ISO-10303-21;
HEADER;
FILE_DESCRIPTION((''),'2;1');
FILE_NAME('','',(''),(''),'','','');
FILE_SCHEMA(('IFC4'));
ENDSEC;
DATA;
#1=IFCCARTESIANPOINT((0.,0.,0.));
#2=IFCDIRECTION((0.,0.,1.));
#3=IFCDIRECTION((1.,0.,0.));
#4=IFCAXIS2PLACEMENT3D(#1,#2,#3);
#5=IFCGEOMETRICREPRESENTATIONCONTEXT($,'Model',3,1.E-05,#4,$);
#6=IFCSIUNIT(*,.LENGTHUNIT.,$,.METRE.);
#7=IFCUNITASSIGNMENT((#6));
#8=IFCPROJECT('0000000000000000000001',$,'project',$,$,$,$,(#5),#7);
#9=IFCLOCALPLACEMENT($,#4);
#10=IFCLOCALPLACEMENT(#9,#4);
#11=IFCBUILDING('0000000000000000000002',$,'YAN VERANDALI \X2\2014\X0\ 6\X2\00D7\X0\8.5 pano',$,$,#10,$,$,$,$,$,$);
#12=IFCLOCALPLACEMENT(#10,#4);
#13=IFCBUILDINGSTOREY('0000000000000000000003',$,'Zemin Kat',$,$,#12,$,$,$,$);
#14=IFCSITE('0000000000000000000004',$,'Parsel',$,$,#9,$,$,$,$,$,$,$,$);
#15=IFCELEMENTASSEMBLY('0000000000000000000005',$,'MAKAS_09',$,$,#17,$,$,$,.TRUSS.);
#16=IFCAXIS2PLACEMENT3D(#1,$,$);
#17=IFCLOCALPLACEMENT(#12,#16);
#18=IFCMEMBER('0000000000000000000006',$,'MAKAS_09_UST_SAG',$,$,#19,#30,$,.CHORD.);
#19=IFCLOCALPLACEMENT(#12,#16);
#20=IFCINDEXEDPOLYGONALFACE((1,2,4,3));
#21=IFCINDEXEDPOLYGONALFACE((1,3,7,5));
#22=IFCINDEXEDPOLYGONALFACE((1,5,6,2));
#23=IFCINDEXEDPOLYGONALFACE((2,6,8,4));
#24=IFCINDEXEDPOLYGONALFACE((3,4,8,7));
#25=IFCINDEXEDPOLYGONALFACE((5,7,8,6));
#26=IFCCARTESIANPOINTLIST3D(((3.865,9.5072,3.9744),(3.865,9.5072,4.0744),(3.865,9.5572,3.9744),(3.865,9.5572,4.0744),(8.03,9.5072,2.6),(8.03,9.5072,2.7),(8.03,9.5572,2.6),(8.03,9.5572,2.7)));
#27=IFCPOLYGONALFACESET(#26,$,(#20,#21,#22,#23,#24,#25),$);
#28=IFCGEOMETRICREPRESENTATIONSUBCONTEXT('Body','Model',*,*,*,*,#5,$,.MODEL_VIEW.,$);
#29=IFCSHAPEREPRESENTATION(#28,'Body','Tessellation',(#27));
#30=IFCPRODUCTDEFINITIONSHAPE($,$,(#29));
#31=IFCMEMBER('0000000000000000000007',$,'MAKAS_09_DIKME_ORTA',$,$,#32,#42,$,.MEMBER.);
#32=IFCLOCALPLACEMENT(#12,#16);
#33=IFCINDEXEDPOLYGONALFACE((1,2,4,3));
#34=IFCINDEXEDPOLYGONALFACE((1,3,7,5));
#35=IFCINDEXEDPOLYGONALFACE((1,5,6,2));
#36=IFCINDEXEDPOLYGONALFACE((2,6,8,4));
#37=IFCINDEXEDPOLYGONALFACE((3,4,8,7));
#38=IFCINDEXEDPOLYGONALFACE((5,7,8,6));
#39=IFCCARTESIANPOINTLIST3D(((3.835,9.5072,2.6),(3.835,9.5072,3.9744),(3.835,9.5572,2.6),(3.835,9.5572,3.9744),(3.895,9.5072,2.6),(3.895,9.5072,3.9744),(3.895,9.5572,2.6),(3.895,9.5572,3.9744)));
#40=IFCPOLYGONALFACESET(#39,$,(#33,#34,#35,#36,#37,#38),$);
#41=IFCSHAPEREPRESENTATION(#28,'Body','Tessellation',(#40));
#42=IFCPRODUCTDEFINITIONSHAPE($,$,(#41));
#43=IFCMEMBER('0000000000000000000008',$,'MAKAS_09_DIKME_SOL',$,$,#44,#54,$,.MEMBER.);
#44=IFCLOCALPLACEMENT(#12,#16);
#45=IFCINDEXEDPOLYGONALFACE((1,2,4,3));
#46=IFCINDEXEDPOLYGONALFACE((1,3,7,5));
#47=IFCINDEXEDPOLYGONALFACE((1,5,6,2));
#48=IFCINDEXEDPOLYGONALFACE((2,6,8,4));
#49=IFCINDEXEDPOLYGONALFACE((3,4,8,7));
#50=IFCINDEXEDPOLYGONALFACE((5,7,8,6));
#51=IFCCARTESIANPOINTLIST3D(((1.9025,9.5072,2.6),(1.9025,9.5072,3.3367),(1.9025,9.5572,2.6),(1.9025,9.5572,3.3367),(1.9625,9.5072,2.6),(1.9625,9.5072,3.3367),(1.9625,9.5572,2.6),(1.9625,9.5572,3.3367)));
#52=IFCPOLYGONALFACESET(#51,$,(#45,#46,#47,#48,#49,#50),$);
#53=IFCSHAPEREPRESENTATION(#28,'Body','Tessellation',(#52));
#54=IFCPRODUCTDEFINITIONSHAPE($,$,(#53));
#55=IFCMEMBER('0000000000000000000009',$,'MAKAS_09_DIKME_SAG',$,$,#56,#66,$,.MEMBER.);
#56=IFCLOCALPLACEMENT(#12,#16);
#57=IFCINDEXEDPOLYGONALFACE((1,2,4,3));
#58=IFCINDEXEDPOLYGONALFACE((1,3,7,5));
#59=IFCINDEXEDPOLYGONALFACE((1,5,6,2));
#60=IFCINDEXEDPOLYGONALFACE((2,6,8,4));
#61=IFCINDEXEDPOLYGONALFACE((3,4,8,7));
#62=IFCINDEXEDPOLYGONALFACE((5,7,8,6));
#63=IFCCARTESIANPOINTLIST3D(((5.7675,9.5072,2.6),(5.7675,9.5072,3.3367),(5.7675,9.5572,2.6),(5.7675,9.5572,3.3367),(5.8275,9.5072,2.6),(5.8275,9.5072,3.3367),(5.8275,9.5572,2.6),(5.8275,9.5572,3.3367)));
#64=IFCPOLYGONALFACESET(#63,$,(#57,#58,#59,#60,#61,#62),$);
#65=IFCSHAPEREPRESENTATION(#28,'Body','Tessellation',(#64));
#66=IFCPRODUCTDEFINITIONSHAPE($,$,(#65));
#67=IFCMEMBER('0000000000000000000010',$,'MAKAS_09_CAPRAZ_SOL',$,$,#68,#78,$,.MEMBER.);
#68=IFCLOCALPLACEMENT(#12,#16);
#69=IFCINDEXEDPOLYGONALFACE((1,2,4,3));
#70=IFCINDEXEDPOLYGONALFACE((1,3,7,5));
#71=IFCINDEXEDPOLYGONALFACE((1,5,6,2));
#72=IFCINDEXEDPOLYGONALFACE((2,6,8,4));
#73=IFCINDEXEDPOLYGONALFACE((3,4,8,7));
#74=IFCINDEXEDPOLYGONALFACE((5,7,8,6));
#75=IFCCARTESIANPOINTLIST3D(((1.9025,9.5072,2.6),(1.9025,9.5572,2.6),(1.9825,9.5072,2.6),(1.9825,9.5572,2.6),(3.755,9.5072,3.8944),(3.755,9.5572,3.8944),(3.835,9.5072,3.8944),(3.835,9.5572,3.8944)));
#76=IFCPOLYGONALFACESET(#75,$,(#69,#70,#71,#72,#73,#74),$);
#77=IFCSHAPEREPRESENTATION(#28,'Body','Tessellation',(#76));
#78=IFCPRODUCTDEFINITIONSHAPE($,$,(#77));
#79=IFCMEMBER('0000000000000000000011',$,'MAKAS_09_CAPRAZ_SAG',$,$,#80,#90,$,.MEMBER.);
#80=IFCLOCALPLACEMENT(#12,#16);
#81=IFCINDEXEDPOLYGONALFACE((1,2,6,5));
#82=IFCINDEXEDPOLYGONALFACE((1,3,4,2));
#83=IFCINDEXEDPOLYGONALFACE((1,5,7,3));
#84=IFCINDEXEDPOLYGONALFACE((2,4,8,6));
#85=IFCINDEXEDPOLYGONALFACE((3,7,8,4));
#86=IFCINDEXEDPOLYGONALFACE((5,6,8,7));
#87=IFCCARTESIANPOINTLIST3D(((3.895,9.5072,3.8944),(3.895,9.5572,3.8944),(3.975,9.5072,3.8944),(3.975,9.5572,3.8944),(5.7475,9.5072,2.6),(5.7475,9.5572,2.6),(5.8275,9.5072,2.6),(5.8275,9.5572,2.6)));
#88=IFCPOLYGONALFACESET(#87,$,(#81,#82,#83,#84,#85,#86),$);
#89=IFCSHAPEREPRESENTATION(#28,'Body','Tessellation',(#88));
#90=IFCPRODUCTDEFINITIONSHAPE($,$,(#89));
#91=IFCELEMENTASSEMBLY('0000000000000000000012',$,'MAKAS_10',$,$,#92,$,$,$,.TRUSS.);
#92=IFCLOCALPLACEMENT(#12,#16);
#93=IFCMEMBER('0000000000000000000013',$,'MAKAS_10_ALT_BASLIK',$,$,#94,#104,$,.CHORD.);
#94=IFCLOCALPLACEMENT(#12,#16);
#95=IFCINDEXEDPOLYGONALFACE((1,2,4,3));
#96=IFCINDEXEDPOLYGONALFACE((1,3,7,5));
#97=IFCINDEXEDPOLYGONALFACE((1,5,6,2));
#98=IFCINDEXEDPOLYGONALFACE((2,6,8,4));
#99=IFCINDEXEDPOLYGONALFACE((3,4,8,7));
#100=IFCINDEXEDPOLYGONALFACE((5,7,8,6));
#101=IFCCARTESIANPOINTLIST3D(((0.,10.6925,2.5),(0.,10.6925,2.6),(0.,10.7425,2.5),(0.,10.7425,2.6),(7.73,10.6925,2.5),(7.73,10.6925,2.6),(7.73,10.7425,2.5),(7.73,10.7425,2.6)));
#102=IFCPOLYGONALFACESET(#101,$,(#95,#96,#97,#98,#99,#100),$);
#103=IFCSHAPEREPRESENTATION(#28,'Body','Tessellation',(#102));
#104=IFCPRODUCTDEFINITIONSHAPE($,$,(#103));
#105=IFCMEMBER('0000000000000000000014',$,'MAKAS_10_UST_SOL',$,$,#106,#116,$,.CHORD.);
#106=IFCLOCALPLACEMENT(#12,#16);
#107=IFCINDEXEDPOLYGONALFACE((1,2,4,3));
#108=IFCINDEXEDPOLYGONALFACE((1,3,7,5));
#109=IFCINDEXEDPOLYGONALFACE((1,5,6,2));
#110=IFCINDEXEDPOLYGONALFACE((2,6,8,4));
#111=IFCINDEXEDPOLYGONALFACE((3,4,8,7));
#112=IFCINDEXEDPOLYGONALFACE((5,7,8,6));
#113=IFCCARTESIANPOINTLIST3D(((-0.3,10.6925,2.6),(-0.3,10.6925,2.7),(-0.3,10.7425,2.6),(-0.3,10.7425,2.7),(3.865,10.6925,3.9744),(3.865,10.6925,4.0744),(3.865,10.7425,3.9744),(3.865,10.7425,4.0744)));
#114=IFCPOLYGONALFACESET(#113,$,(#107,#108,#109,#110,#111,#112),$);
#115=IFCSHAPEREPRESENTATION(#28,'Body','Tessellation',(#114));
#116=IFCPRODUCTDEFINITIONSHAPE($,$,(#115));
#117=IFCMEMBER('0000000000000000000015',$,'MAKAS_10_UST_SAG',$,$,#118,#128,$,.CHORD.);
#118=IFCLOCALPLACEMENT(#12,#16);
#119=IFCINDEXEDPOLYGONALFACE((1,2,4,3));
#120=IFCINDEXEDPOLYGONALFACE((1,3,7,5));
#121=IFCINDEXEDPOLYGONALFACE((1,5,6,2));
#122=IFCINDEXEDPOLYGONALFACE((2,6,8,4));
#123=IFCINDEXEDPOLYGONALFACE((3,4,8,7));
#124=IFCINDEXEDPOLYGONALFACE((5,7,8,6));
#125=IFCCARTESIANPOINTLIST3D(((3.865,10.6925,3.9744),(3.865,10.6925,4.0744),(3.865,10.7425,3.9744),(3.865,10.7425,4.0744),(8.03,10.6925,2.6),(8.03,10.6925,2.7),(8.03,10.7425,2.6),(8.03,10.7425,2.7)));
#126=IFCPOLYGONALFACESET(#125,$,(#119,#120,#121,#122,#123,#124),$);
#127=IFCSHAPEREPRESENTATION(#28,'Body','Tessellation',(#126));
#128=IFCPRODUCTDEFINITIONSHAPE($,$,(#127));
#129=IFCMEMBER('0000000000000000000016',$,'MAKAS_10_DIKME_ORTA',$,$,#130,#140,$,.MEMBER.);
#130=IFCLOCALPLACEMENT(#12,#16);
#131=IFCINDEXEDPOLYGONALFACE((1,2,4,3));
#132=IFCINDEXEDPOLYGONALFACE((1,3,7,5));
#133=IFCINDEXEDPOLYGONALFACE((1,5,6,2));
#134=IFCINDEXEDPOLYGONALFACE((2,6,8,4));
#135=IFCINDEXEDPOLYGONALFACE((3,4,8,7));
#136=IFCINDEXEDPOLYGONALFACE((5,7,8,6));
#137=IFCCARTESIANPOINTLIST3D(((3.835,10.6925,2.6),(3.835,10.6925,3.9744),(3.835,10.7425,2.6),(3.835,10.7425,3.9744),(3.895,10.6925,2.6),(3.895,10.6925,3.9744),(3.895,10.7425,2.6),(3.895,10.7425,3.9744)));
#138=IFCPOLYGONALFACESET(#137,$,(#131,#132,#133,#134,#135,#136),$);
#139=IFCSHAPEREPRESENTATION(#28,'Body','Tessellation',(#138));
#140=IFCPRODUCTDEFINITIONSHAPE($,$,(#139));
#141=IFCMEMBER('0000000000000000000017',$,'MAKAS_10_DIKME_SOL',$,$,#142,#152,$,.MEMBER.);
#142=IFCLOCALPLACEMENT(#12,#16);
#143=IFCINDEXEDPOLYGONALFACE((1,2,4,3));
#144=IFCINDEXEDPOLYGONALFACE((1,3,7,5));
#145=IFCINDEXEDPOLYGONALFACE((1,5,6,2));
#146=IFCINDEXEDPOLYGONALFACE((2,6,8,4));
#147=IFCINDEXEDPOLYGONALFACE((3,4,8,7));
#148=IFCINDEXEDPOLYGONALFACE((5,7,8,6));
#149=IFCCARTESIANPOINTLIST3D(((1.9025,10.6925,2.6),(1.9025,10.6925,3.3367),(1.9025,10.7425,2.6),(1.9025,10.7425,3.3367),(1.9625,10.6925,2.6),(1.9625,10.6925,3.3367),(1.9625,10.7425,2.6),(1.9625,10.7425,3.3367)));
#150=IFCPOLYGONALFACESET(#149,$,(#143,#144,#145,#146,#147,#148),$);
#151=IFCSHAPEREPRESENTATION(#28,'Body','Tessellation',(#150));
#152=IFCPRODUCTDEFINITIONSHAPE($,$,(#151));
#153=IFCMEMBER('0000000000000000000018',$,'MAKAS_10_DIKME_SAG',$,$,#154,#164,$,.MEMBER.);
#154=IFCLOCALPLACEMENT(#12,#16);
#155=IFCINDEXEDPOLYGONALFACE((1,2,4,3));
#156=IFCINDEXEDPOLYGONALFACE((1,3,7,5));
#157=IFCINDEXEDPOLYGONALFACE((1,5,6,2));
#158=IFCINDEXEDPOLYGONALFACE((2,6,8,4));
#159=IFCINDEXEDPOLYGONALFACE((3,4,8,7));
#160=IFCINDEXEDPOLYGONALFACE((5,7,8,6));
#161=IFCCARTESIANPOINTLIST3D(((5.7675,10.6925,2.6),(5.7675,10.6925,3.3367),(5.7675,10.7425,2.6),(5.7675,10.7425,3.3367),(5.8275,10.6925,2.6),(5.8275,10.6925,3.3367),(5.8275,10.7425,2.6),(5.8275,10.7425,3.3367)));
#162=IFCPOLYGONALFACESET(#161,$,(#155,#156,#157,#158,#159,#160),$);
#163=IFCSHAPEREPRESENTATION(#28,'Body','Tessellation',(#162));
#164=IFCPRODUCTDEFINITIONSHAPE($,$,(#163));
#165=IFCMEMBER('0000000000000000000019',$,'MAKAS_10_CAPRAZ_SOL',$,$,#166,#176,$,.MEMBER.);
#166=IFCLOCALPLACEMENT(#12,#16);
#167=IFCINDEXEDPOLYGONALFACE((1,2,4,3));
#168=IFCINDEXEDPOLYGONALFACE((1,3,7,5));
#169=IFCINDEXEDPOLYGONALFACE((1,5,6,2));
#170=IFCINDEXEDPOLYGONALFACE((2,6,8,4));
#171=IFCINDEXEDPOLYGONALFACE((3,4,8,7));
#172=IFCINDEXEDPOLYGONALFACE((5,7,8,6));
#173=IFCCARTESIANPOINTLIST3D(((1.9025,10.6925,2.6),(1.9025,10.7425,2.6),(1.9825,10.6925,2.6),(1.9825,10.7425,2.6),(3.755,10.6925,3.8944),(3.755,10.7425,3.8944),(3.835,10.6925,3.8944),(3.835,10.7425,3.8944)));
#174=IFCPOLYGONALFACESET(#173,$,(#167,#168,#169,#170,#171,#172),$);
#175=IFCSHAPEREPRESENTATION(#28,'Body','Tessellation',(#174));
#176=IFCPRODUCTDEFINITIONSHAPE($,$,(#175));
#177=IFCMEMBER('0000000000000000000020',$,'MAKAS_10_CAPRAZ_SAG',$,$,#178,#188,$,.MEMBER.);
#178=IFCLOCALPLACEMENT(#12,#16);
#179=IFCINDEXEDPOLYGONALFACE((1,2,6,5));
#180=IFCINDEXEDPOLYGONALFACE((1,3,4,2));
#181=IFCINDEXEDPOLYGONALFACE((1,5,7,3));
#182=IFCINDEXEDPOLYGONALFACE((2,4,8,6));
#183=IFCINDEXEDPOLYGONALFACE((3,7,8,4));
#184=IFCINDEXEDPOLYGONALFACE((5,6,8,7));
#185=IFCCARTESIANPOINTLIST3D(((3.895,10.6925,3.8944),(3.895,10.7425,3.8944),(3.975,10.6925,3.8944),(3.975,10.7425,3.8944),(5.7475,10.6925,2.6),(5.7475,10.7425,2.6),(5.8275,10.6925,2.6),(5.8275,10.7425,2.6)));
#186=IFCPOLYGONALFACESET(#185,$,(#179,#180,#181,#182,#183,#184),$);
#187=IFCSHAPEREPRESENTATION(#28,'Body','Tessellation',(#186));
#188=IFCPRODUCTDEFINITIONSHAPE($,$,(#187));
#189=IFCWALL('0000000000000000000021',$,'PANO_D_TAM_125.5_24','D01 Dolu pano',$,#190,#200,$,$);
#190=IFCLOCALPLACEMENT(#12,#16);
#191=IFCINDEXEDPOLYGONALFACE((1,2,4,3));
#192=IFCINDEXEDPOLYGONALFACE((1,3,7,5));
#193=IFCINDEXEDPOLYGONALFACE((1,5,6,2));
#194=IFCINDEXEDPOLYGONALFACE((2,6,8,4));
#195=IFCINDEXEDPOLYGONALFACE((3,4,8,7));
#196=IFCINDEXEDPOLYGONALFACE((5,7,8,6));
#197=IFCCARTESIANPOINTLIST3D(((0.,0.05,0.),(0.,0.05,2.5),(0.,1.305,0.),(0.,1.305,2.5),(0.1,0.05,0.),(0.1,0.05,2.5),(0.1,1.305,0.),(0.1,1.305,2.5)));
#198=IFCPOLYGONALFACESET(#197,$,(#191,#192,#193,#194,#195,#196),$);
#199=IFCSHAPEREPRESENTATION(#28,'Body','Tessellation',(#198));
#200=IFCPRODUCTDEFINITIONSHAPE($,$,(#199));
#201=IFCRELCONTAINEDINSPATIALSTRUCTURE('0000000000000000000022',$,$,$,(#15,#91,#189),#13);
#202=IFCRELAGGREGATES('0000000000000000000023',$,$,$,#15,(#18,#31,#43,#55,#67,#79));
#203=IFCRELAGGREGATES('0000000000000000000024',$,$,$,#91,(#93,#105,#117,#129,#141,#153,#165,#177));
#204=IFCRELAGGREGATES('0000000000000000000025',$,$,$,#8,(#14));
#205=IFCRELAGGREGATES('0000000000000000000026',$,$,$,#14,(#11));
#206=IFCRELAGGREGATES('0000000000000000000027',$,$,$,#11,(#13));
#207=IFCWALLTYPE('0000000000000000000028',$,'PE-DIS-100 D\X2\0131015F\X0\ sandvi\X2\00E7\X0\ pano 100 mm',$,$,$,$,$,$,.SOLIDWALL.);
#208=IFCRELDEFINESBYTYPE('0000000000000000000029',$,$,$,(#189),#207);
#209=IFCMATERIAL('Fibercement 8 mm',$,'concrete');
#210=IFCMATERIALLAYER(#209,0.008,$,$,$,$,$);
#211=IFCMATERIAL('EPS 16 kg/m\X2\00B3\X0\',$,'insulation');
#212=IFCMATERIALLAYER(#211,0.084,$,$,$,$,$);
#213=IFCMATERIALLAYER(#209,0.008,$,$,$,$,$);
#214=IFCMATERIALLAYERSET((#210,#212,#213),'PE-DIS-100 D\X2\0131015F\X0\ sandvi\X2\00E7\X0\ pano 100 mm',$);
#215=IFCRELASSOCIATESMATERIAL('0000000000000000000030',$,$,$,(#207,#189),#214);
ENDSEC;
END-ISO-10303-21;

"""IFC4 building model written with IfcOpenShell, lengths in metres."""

from ifc_helpers import new_model, si_unit, frame, origin_with_axes, place, context, subcontext, project, spatial, line, indexed_curve, outline, extrude, material, layer, layer_set, layer_usage, type_object, element, aggregate, save


model = new_model("IFC4")

# Units and contexts
model_context = context("Model", 3, precision=1e-05, world=origin_with_axes())
body_context = subcontext(model_context, "Body", "Model", "MODEL_VIEW")
ifc_project = project(units=[si_unit("LENGTHUNIT", "METRE")], contexts=[model_context])

# Site, building, storey
site_placement = place(None, origin_with_axes())
site = spatial("IfcSite", under=ifc_project, at=site_placement, Name="Parsel")
building_placement = place(site_placement, origin_with_axes())
building = spatial("IfcBuilding", under=site, at=building_placement, Name="YAN VERANDALI — 6×8.5 pano")
storey_placement = place(building_placement, origin_with_axes())
storey = spatial("IfcBuildingStorey", under=building, at=storey_placement, Name="Zemin Kat")

# Element assemblies, members
assembly_1_placement = place(storey_placement, origin_with_axes())
assembly_1 = element("IfcElementAssembly", 1, at=assembly_1_placement, inside=storey, Name="MAKAS_09", PredefinedType="TRUSS")
member_1_placement = place(assembly_1_placement, origin_with_axes())
member_1 = element("IfcMember", 2, at=member_1_placement, Name="MAKAS_09_UST_SAG", PredefinedType="CHORD", context=body_context, shape_type="SweptSolid", body=[
    extrude(outline(indexed_curve([(3.865, 3.9745), (8.03, 2.6), (8.03, 2.7), (3.865, 4.0744)], segments=[line(1, 2, 3, 4, 1)])), frame((0.0, 9.5572, 0.0), z_axis=(0.0, -1.0, 0.0), x_axis=(1.0, 0.0, 0.0)), (0.0, 0.0, 1.0), 0.05),
])
member_2_placement = place(assembly_1_placement, origin_with_axes())
member_2 = element("IfcMember", 3, at=member_2_placement, Name="MAKAS_09_DIKME_ORTA", PredefinedType="MEMBER", context=body_context, shape_type="SweptSolid", body=[
    extrude(outline(indexed_curve([(3.835, 2.6), (3.895, 2.6), (3.895, 3.9745), (3.835, 3.9745)], segments=[line(1, 2, 3, 4, 1)])), frame((0.0, 9.5572, 0.0), z_axis=(0.0, -1.0, 0.0), x_axis=(1.0, 0.0, 0.0)), (0.0, 0.0, 1.0), 0.05),
])
member_3_placement = place(assembly_1_placement, origin_with_axes())
member_3 = element("IfcMember", 4, at=member_3_placement, Name="MAKAS_09_DIKME_SOL", PredefinedType="MEMBER", context=body_context, shape_type="SweptSolid", body=[
    extrude(outline(indexed_curve([(1.9025, 2.6), (1.9625, 2.6), (1.9625, 3.3367), (1.9025, 3.3367)], segments=[line(1, 2, 3, 4, 1)])), frame((0.0, 9.5572, 0.0), z_axis=(0.0, -1.0, 0.0), x_axis=(1.0, 0.0, 0.0)), (0.0, 0.0, 1.0), 0.05),
])
member_4_placement = place(assembly_1_placement, origin_with_axes())
member_4 = element("IfcMember", 5, at=member_4_placement, Name="MAKAS_09_DIKME_SAG", PredefinedType="MEMBER", context=body_context, shape_type="SweptSolid", body=[
    extrude(outline(indexed_curve([(5.7675, 2.6), (5.8275, 2.6), (5.8275, 3.3367), (5.7675, 3.3367)], segments=[line(1, 2, 3, 4, 1)])), frame((0.0, 9.5572, 0.0), z_axis=(0.0, -1.0, 0.0), x_axis=(1.0, 0.0, 0.0)), (0.0, 0.0, 1.0), 0.05),
])
member_5_placement = place(assembly_1_placement, origin_with_axes())
member_5 = element("IfcMember", 6, at=member_5_placement, Name="MAKAS_09_CAPRAZ_SOL", PredefinedType="MEMBER", context=body_context, shape_type="SweptSolid", body=[
    extrude(outline(indexed_curve([(1.9025, 2.6), (1.9825, 2.6), (3.835, 3.8944), (3.755, 3.8944)], segments=[line(1, 2, 3, 4, 1)])), frame((0.0, 9.5572, 0.0), z_axis=(0.0, -1.0, 0.0), x_axis=(1.0, 0.0, 0.0)), (0.0, 0.0, 1.0), 0.05),
])
member_6_placement = place(assembly_1_placement, origin_with_axes())
member_6 = element("IfcMember", 7, at=member_6_placement, Name="MAKAS_09_CAPRAZ_SAG", PredefinedType="MEMBER", context=body_context, shape_type="SweptSolid", body=[
    extrude(outline(indexed_curve([(5.7475, 2.6), (5.8275, 2.6), (3.975, 3.8944), (3.895, 3.8944)], segments=[line(1, 2, 3, 4, 1)])), frame((0.0, 9.5572, 0.0), z_axis=(0.0, -1.0, 0.0), x_axis=(1.0, 0.0, 0.0)), (0.0, 0.0, 1.0), 0.05),
])
aggregate(assembly_1, [member_1, member_2, member_3, member_4, member_5, member_6])
assembly_2_placement = place(storey_placement, origin_with_axes())
assembly_2 = element("IfcElementAssembly", 8, at=assembly_2_placement, inside=storey, Name="MAKAS_10", PredefinedType="TRUSS")
member_7_placement = place(assembly_2_placement, origin_with_axes())
member_7 = element("IfcMember", 9, at=member_7_placement, Name="MAKAS_10_ALT_BASLIK", PredefinedType="CHORD", context=body_context, shape_type="SweptSolid", body=[
    extrude(outline(indexed_curve([(0.0, 2.5), (7.73, 2.5), (7.73, 2.6), (0.0, 2.6)], segments=[line(1, 2, 3, 4, 1)])), frame((0.0, 10.7425, 0.0), z_axis=(0.0, -1.0, 0.0), x_axis=(1.0, 0.0, 0.0)), (0.0, 0.0, 1.0), 0.05),
])
member_8_placement = place(assembly_2_placement, origin_with_axes())
member_8 = element("IfcMember", 10, at=member_8_placement, Name="MAKAS_10_UST_SOL", PredefinedType="CHORD", context=body_context, shape_type="SweptSolid", body=[
    extrude(outline(indexed_curve([(-0.3, 2.6), (3.865, 3.9745), (3.865, 4.0744), (-0.3, 2.7)], segments=[line(1, 2, 3, 4, 1)])), frame((0.0, 10.7425, 0.0), z_axis=(0.0, -1.0, 0.0), x_axis=(1.0, 0.0, 0.0)), (0.0, 0.0, 1.0), 0.05),
])
member_9_placement = place(assembly_2_placement, origin_with_axes())
member_9 = element("IfcMember", 11, at=member_9_placement, Name="MAKAS_10_UST_SAG", PredefinedType="CHORD", context=body_context, shape_type="SweptSolid", body=[
    extrude(outline(indexed_curve([(3.865, 3.9745), (8.03, 2.6), (8.03, 2.7), (3.865, 4.0744)], segments=[line(1, 2, 3, 4, 1)])), frame((0.0, 10.7425, 0.0), z_axis=(0.0, -1.0, 0.0), x_axis=(1.0, 0.0, 0.0)), (0.0, 0.0, 1.0), 0.05),
])
member_10_placement = place(assembly_2_placement, origin_with_axes())
member_10 = element("IfcMember", 12, at=member_10_placement, Name="MAKAS_10_DIKME_ORTA", PredefinedType="MEMBER", context=body_context, shape_type="SweptSolid", body=[
    extrude(outline(indexed_curve([(3.835, 2.6), (3.895, 2.6), (3.895, 3.9745), (3.835, 3.9745)], segments=[line(1, 2, 3, 4, 1)])), frame((0.0, 10.7425, 0.0), z_axis=(0.0, -1.0, 0.0), x_axis=(1.0, 0.0, 0.0)), (0.0, 0.0, 1.0), 0.05),
])
member_11_placement = place(assembly_2_placement, origin_with_axes())
member_11 = element("IfcMember", 13, at=member_11_placement, Name="MAKAS_10_DIKME_SOL", PredefinedType="MEMBER", context=body_context, shape_type="SweptSolid", body=[
    extrude(outline(indexed_curve([(1.9025, 2.6), (1.9625, 2.6), (1.9625, 3.3367), (1.9025, 3.3367)], segments=[line(1, 2, 3, 4, 1)])), frame((0.0, 10.7425, 0.0), z_axis=(0.0, -1.0, 0.0), x_axis=(1.0, 0.0, 0.0)), (0.0, 0.0, 1.0), 0.05),
])
member_12_placement = place(assembly_2_placement, origin_with_axes())
member_12 = element("IfcMember", 14, at=member_12_placement, Name="MAKAS_10_DIKME_SAG", PredefinedType="MEMBER", context=body_context, shape_type="SweptSolid", body=[
    extrude(outline(indexed_curve([(5.7675, 2.6), (5.8275, 2.6), (5.8275, 3.3367), (5.7675, 3.3367)], segments=[line(1, 2, 3, 4, 1)])), frame((0.0, 10.7425, 0.0), z_axis=(0.0, -1.0, 0.0), x_axis=(1.0, 0.0, 0.0)), (0.0, 0.0, 1.0), 0.05),
])
member_13_placement = place(assembly_2_placement, origin_with_axes())
member_13 = element("IfcMember", 15, at=member_13_placement, Name="MAKAS_10_CAPRAZ_SOL", PredefinedType="MEMBER", context=body_context, shape_type="SweptSolid", body=[
    extrude(outline(indexed_curve([(1.9025, 2.6), (1.9825, 2.6), (3.835, 3.8944), (3.755, 3.8944)], segments=[line(1, 2, 3, 4, 1)])), frame((0.0, 10.7425, 0.0), z_axis=(0.0, -1.0, 0.0), x_axis=(1.0, 0.0, 0.0)), (0.0, 0.0, 1.0), 0.05),
])
member_14_placement = place(assembly_2_placement, origin_with_axes())
member_14 = element("IfcMember", 16, at=member_14_placement, Name="MAKAS_10_CAPRAZ_SAG", PredefinedType="MEMBER", context=body_context, shape_type="SweptSolid", body=[
    extrude(outline(indexed_curve([(5.7475, 2.6), (5.8275, 2.6), (3.975, 3.8944), (3.895, 3.8944)], segments=[line(1, 2, 3, 4, 1)])), frame((0.0, 10.7425, 0.0), z_axis=(0.0, -1.0, 0.0), x_axis=(1.0, 0.0, 0.0)), (0.0, 0.0, 1.0), 0.05),
])
aggregate(assembly_2, [member_7, member_8, member_9, member_10, member_11, member_12, member_13, member_14])

# Wall
ifc_material_1 = material(Name="Fibercement 8 mm", Category="concrete")
ifc_layer_1 = layer(ifc_material_1, 0.008)
ifc_material_2 = material(Name="EPS 16 kg/m³", Category="insulation")
ifc_layer_2 = layer(ifc_material_2, 0.084)
ifc_layer_3 = layer(ifc_material_1, 0.008)
ifc_layer_set_1 = layer_set([ifc_layer_1, ifc_layer_2, ifc_layer_3], Name="PE-DIS-100 Dış sandviç pano 100 mm")
ifc_layer_usage_1 = layer_usage(ifc_layer_set_1, "AXIS2", "POSITIVE", 0.0)
wall_type_1 = type_object("IfcWallType", Name="PE-DIS-100 Dış sandviç pano 100 mm", PredefinedType="SOLIDWALL", material=ifc_layer_set_1)
wall_1_placement = place(storey_placement, frame((0.1, 0.05, 0.0), z_axis=(0.0, 0.0, 1.0), x_axis=(0.0, 1.0, 0.0)))
element("IfcWall", 17, at=wall_1_placement, inside=storey, type_object=wall_type_1, material=ifc_layer_usage_1, Name="PANO_D_TAM_125.5_24", Description="D01 Dolu pano", context=body_context, shape_type="SweptSolid", body=[
    extrude(outline(indexed_curve([(0.0, 0.0), (1.255, 0.0), (1.255, 0.1), (0.0, 0.1)], segments=[line(1, 2, 3, 4, 1)])), origin_with_axes(), (0.0, 0.0, 1.0), 2.5),
])

save(model, "model.ifc")
